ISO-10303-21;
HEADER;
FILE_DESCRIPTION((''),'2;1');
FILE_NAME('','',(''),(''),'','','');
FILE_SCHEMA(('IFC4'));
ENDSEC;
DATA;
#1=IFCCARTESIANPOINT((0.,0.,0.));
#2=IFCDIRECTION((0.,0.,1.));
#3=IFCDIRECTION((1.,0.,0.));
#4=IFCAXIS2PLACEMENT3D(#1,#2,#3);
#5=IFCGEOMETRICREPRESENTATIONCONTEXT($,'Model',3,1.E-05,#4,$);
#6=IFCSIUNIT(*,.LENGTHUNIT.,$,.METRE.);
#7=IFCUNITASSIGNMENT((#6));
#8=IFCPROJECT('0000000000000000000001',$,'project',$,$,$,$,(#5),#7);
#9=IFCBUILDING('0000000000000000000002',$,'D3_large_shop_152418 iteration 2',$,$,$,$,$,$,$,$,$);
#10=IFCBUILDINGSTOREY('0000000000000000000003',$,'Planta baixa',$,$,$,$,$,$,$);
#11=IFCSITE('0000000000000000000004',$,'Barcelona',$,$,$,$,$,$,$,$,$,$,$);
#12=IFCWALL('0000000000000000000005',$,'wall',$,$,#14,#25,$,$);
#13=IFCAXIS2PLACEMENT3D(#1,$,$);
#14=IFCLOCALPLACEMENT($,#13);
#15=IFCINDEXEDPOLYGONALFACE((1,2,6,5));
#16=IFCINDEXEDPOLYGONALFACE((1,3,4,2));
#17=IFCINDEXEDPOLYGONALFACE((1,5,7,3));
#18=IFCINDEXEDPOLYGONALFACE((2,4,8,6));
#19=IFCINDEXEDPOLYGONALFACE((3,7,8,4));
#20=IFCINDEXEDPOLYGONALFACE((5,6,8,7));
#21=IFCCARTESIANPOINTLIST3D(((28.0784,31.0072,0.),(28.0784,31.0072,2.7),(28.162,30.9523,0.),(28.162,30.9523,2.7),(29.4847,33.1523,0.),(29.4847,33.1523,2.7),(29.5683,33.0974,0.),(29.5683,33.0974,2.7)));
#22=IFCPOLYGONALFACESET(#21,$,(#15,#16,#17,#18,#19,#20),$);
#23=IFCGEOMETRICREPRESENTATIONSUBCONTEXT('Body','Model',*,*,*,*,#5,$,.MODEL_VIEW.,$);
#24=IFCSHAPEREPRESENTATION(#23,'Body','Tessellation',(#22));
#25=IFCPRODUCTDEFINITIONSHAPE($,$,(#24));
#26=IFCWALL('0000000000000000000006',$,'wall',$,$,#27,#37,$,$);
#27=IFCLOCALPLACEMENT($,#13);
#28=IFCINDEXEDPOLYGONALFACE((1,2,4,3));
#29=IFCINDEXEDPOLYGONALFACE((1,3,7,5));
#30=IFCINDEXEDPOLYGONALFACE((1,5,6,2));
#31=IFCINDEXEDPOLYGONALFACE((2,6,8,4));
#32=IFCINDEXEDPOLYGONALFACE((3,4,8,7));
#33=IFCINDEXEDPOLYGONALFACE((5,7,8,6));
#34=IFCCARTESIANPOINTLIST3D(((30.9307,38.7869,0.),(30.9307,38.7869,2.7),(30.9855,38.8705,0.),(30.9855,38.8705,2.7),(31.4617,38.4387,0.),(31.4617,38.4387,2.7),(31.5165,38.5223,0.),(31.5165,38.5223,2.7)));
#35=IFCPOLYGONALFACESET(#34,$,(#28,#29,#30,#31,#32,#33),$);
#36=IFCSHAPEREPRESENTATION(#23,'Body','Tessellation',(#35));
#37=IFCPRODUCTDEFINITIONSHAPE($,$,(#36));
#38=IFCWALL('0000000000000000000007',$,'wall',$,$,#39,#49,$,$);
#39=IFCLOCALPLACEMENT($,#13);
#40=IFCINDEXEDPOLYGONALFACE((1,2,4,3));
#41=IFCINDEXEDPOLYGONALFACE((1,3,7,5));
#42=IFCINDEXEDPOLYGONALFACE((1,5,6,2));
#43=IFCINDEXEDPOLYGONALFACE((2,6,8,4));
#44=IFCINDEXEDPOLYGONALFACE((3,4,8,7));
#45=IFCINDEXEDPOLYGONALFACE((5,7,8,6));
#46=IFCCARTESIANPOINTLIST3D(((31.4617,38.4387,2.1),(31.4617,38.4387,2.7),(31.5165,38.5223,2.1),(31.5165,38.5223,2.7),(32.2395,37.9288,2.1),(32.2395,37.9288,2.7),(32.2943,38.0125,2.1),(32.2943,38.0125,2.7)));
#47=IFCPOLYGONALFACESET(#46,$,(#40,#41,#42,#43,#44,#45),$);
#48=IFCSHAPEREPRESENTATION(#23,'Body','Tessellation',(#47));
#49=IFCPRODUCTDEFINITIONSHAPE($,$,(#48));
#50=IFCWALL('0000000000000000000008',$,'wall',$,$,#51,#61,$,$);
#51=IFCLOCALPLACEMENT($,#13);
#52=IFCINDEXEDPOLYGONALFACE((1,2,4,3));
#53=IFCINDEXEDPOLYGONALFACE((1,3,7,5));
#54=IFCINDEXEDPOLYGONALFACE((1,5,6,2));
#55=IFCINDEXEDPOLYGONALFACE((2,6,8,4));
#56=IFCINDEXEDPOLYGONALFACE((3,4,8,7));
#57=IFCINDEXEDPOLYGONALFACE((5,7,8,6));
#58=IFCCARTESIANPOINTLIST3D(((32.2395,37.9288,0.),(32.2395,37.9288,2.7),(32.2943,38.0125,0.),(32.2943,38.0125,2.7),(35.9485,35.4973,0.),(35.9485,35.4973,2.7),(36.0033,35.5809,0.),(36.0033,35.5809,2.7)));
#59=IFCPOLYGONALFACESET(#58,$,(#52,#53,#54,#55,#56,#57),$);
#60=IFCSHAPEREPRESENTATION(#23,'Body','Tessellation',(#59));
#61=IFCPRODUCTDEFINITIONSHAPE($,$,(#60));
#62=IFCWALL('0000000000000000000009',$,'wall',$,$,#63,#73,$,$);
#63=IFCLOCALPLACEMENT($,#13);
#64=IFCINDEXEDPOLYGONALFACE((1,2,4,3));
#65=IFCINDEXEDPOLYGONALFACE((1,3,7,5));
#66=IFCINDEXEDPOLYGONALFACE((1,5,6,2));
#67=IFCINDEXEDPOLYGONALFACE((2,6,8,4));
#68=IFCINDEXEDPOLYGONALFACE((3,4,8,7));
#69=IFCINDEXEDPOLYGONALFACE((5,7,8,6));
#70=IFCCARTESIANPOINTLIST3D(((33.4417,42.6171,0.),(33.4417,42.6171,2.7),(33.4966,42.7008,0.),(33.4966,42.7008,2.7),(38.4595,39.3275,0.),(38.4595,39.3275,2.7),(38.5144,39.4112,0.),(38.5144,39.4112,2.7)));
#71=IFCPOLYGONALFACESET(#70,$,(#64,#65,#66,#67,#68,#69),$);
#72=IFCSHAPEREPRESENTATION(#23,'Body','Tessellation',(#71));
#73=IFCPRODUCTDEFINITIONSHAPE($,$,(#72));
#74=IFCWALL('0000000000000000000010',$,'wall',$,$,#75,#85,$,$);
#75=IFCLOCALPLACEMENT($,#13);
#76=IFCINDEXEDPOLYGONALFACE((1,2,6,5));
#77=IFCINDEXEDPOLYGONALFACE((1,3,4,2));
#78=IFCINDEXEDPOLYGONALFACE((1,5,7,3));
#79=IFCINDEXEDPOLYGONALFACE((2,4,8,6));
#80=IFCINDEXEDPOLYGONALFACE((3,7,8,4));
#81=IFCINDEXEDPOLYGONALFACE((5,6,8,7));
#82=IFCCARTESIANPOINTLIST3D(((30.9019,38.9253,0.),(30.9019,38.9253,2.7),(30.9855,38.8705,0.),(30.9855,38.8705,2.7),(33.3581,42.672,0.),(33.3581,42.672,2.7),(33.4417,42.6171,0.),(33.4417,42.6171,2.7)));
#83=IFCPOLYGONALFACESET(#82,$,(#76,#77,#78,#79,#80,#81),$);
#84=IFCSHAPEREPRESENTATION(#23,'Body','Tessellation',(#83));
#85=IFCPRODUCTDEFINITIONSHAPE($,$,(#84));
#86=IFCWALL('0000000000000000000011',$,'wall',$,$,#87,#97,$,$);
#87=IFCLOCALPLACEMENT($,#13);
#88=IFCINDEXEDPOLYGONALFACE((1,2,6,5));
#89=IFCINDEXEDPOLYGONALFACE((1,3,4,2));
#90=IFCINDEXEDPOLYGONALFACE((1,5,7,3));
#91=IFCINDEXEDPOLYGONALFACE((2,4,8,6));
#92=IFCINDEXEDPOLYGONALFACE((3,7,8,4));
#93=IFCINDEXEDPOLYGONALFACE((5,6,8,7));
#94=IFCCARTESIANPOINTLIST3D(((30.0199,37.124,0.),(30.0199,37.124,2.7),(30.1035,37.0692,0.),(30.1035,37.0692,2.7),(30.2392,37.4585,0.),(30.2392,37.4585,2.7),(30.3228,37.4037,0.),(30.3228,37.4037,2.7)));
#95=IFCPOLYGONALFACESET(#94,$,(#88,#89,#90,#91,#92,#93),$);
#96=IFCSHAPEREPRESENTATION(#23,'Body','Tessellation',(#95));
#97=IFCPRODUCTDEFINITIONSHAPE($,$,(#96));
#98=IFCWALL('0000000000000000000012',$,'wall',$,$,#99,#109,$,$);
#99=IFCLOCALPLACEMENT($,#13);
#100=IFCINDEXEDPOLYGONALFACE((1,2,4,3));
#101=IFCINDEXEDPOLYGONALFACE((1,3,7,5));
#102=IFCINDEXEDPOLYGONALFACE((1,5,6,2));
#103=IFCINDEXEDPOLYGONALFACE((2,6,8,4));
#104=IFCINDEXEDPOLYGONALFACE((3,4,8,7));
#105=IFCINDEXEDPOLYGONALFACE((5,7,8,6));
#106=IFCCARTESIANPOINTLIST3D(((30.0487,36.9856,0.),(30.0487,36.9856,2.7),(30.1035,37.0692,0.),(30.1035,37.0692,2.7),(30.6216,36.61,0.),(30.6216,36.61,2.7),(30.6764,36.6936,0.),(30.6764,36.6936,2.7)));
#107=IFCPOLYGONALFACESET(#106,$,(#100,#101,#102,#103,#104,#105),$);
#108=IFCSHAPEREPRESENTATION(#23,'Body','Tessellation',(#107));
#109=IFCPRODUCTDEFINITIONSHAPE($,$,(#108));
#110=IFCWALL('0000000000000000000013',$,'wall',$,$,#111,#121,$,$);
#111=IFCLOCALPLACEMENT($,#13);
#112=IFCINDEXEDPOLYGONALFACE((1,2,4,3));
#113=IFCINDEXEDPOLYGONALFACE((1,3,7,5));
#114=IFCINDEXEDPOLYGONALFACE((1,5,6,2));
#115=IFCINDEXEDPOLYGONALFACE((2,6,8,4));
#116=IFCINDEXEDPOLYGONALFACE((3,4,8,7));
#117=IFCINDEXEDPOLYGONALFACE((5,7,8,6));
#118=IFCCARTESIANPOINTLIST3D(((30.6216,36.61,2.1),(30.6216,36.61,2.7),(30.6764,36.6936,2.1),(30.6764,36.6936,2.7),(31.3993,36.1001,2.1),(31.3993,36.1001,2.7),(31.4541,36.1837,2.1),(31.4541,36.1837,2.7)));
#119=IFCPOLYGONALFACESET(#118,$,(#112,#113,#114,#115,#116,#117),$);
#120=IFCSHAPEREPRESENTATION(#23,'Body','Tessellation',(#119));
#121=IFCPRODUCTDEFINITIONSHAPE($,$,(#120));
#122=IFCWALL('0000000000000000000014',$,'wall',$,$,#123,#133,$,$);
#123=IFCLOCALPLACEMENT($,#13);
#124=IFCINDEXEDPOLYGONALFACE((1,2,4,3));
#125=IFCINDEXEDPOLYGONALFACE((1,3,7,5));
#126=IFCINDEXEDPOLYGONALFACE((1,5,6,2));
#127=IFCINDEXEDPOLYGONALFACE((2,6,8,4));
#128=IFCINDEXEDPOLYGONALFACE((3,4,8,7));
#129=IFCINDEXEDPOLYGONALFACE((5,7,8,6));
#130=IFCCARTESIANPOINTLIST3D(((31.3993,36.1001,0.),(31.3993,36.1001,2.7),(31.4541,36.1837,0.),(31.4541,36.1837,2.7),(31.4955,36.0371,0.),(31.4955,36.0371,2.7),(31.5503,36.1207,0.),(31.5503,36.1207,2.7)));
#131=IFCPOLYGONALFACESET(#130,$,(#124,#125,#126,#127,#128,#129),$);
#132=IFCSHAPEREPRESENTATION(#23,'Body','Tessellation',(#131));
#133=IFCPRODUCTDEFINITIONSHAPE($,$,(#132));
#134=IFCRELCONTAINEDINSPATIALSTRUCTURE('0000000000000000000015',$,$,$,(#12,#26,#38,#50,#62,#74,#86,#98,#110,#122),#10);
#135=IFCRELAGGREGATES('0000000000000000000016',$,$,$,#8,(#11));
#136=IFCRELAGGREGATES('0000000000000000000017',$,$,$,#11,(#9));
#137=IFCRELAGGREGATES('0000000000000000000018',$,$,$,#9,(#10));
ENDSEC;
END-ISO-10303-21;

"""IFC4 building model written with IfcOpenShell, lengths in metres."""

from ifc_helpers import new_model, si_unit, frame, origin, origin_with_axes, place, context, subcontext, project, spatial, polyline, outline, extrude, element, save


model = new_model("IFC4")

# Units and contexts
model_context = context("Model", 3, precision=1e-05, world=origin_with_axes())
body_context = subcontext(model_context, "Body", "Model", "MODEL_VIEW")
ifc_project = project(units=[si_unit("LENGTHUNIT", "METRE")], contexts=[model_context])

# Site, building, storey
site = spatial("IfcSite", under=ifc_project, Name="Barcelona")
building = spatial("IfcBuilding", under=site, Name="D3_large_shop_152418 iteration 2")
storey = spatial("IfcBuildingStorey", under=building, Name="Planta baixa")

# Walls
wall_1_placement = place(None, origin_with_axes())
element("IfcWall", 1, at=wall_1_placement, inside=storey, Name="wall", context=body_context, shape_type="SweptSolid", body=[
    extrude(outline(polyline([(29.5683, 33.0974), (28.162, 30.9523), (28.0784, 31.0072), (29.4847, 33.1523), (29.5683, 33.0974)])), origin(), (0.0, 0.0, 1.0), 2.7),
])
wall_2_placement = place(None, origin_with_axes())
element("IfcWall", 2, at=wall_2_placement, inside=storey, Name="wall", context=body_context, shape_type="SweptSolid", body=[
    extrude(outline(polyline([(30.9855, 38.8705), (31.5165, 38.5223), (31.4617, 38.4387), (30.9307, 38.7869), (30.9855, 38.8705)])), origin(), (0.0, 0.0, 1.0), 2.7),
])
wall_3_placement = place(None, origin_with_axes())
element("IfcWall", 3, at=wall_3_placement, inside=storey, Name="wall", context=body_context, shape_type="SweptSolid", body=[
    extrude(outline(polyline([(31.5165, 38.5223), (32.2943, 38.0125), (32.2395, 37.9288), (31.4617, 38.4387), (31.5165, 38.5223)])), frame((0.0, 0.0, 2.1)), (0.0, 0.0, 1.0), 0.6),
])
wall_4_placement = place(None, origin_with_axes())
element("IfcWall", 4, at=wall_4_placement, inside=storey, Name="wall", context=body_context, shape_type="SweptSolid", body=[
    extrude(outline(polyline([(32.2943, 38.0125), (36.0033, 35.5809), (35.9485, 35.4973), (32.2395, 37.9288), (32.2943, 38.0125)])), origin(), (0.0, 0.0, 1.0), 2.7),
])
wall_5_placement = place(None, origin_with_axes())
element("IfcWall", 5, at=wall_5_placement, inside=storey, Name="wall", context=body_context, shape_type="SweptSolid", body=[
    extrude(outline(polyline([(38.4595, 39.3275), (33.4417, 42.6171), (33.4966, 42.7008), (38.5144, 39.4112), (38.4595, 39.3275)])), origin(), (0.0, 0.0, 1.0), 2.7),
])
wall_6_placement = place(None, origin_with_axes())
element("IfcWall", 6, at=wall_6_placement, inside=storey, Name="wall", context=body_context, shape_type="SweptSolid", body=[
    extrude(outline(polyline([(33.4417, 42.6171), (30.9855, 38.8705), (30.9019, 38.9253), (33.3581, 42.672), (33.4417, 42.6171)])), origin(), (0.0, 0.0, 1.0), 2.7),
])
wall_7_placement = place(None, origin_with_axes())
element("IfcWall", 7, at=wall_7_placement, inside=storey, Name="wall", context=body_context, shape_type="SweptSolid", body=[
    extrude(outline(polyline([(30.3228, 37.4037), (30.1035, 37.0692), (30.0199, 37.124), (30.2392, 37.4585), (30.3228, 37.4037)])), origin(), (0.0, 0.0, 1.0), 2.7),
])
wall_8_placement = place(None, origin_with_axes())
element("IfcWall", 8, at=wall_8_placement, inside=storey, Name="wall", context=body_context, shape_type="SweptSolid", body=[
    extrude(outline(polyline([(30.1035, 37.0692), (30.6764, 36.6936), (30.6216, 36.61), (30.0487, 36.9856), (30.1035, 37.0692)])), origin(), (0.0, 0.0, 1.0), 2.7),
])
wall_9_placement = place(None, origin_with_axes())
element("IfcWall", 9, at=wall_9_placement, inside=storey, Name="wall", context=body_context, shape_type="SweptSolid", body=[
    extrude(outline(polyline([(30.6764, 36.6936), (31.4541, 36.1837), (31.3993, 36.1001), (30.6216, 36.61), (30.6764, 36.6936)])), frame((0.0, 0.0, 2.1)), (0.0, 0.0, 1.0), 0.6),
])
wall_10_placement = place(None, origin_with_axes())
element("IfcWall", 10, at=wall_10_placement, inside=storey, Name="wall", context=body_context, shape_type="SweptSolid", body=[
    extrude(outline(polyline([(31.4541, 36.1837), (31.5503, 36.1207), (31.4955, 36.0371), (31.3993, 36.1001), (31.4541, 36.1837)])), origin(), (0.0, 0.0, 1.0), 2.7),
])

save(model, "model.ifc")
